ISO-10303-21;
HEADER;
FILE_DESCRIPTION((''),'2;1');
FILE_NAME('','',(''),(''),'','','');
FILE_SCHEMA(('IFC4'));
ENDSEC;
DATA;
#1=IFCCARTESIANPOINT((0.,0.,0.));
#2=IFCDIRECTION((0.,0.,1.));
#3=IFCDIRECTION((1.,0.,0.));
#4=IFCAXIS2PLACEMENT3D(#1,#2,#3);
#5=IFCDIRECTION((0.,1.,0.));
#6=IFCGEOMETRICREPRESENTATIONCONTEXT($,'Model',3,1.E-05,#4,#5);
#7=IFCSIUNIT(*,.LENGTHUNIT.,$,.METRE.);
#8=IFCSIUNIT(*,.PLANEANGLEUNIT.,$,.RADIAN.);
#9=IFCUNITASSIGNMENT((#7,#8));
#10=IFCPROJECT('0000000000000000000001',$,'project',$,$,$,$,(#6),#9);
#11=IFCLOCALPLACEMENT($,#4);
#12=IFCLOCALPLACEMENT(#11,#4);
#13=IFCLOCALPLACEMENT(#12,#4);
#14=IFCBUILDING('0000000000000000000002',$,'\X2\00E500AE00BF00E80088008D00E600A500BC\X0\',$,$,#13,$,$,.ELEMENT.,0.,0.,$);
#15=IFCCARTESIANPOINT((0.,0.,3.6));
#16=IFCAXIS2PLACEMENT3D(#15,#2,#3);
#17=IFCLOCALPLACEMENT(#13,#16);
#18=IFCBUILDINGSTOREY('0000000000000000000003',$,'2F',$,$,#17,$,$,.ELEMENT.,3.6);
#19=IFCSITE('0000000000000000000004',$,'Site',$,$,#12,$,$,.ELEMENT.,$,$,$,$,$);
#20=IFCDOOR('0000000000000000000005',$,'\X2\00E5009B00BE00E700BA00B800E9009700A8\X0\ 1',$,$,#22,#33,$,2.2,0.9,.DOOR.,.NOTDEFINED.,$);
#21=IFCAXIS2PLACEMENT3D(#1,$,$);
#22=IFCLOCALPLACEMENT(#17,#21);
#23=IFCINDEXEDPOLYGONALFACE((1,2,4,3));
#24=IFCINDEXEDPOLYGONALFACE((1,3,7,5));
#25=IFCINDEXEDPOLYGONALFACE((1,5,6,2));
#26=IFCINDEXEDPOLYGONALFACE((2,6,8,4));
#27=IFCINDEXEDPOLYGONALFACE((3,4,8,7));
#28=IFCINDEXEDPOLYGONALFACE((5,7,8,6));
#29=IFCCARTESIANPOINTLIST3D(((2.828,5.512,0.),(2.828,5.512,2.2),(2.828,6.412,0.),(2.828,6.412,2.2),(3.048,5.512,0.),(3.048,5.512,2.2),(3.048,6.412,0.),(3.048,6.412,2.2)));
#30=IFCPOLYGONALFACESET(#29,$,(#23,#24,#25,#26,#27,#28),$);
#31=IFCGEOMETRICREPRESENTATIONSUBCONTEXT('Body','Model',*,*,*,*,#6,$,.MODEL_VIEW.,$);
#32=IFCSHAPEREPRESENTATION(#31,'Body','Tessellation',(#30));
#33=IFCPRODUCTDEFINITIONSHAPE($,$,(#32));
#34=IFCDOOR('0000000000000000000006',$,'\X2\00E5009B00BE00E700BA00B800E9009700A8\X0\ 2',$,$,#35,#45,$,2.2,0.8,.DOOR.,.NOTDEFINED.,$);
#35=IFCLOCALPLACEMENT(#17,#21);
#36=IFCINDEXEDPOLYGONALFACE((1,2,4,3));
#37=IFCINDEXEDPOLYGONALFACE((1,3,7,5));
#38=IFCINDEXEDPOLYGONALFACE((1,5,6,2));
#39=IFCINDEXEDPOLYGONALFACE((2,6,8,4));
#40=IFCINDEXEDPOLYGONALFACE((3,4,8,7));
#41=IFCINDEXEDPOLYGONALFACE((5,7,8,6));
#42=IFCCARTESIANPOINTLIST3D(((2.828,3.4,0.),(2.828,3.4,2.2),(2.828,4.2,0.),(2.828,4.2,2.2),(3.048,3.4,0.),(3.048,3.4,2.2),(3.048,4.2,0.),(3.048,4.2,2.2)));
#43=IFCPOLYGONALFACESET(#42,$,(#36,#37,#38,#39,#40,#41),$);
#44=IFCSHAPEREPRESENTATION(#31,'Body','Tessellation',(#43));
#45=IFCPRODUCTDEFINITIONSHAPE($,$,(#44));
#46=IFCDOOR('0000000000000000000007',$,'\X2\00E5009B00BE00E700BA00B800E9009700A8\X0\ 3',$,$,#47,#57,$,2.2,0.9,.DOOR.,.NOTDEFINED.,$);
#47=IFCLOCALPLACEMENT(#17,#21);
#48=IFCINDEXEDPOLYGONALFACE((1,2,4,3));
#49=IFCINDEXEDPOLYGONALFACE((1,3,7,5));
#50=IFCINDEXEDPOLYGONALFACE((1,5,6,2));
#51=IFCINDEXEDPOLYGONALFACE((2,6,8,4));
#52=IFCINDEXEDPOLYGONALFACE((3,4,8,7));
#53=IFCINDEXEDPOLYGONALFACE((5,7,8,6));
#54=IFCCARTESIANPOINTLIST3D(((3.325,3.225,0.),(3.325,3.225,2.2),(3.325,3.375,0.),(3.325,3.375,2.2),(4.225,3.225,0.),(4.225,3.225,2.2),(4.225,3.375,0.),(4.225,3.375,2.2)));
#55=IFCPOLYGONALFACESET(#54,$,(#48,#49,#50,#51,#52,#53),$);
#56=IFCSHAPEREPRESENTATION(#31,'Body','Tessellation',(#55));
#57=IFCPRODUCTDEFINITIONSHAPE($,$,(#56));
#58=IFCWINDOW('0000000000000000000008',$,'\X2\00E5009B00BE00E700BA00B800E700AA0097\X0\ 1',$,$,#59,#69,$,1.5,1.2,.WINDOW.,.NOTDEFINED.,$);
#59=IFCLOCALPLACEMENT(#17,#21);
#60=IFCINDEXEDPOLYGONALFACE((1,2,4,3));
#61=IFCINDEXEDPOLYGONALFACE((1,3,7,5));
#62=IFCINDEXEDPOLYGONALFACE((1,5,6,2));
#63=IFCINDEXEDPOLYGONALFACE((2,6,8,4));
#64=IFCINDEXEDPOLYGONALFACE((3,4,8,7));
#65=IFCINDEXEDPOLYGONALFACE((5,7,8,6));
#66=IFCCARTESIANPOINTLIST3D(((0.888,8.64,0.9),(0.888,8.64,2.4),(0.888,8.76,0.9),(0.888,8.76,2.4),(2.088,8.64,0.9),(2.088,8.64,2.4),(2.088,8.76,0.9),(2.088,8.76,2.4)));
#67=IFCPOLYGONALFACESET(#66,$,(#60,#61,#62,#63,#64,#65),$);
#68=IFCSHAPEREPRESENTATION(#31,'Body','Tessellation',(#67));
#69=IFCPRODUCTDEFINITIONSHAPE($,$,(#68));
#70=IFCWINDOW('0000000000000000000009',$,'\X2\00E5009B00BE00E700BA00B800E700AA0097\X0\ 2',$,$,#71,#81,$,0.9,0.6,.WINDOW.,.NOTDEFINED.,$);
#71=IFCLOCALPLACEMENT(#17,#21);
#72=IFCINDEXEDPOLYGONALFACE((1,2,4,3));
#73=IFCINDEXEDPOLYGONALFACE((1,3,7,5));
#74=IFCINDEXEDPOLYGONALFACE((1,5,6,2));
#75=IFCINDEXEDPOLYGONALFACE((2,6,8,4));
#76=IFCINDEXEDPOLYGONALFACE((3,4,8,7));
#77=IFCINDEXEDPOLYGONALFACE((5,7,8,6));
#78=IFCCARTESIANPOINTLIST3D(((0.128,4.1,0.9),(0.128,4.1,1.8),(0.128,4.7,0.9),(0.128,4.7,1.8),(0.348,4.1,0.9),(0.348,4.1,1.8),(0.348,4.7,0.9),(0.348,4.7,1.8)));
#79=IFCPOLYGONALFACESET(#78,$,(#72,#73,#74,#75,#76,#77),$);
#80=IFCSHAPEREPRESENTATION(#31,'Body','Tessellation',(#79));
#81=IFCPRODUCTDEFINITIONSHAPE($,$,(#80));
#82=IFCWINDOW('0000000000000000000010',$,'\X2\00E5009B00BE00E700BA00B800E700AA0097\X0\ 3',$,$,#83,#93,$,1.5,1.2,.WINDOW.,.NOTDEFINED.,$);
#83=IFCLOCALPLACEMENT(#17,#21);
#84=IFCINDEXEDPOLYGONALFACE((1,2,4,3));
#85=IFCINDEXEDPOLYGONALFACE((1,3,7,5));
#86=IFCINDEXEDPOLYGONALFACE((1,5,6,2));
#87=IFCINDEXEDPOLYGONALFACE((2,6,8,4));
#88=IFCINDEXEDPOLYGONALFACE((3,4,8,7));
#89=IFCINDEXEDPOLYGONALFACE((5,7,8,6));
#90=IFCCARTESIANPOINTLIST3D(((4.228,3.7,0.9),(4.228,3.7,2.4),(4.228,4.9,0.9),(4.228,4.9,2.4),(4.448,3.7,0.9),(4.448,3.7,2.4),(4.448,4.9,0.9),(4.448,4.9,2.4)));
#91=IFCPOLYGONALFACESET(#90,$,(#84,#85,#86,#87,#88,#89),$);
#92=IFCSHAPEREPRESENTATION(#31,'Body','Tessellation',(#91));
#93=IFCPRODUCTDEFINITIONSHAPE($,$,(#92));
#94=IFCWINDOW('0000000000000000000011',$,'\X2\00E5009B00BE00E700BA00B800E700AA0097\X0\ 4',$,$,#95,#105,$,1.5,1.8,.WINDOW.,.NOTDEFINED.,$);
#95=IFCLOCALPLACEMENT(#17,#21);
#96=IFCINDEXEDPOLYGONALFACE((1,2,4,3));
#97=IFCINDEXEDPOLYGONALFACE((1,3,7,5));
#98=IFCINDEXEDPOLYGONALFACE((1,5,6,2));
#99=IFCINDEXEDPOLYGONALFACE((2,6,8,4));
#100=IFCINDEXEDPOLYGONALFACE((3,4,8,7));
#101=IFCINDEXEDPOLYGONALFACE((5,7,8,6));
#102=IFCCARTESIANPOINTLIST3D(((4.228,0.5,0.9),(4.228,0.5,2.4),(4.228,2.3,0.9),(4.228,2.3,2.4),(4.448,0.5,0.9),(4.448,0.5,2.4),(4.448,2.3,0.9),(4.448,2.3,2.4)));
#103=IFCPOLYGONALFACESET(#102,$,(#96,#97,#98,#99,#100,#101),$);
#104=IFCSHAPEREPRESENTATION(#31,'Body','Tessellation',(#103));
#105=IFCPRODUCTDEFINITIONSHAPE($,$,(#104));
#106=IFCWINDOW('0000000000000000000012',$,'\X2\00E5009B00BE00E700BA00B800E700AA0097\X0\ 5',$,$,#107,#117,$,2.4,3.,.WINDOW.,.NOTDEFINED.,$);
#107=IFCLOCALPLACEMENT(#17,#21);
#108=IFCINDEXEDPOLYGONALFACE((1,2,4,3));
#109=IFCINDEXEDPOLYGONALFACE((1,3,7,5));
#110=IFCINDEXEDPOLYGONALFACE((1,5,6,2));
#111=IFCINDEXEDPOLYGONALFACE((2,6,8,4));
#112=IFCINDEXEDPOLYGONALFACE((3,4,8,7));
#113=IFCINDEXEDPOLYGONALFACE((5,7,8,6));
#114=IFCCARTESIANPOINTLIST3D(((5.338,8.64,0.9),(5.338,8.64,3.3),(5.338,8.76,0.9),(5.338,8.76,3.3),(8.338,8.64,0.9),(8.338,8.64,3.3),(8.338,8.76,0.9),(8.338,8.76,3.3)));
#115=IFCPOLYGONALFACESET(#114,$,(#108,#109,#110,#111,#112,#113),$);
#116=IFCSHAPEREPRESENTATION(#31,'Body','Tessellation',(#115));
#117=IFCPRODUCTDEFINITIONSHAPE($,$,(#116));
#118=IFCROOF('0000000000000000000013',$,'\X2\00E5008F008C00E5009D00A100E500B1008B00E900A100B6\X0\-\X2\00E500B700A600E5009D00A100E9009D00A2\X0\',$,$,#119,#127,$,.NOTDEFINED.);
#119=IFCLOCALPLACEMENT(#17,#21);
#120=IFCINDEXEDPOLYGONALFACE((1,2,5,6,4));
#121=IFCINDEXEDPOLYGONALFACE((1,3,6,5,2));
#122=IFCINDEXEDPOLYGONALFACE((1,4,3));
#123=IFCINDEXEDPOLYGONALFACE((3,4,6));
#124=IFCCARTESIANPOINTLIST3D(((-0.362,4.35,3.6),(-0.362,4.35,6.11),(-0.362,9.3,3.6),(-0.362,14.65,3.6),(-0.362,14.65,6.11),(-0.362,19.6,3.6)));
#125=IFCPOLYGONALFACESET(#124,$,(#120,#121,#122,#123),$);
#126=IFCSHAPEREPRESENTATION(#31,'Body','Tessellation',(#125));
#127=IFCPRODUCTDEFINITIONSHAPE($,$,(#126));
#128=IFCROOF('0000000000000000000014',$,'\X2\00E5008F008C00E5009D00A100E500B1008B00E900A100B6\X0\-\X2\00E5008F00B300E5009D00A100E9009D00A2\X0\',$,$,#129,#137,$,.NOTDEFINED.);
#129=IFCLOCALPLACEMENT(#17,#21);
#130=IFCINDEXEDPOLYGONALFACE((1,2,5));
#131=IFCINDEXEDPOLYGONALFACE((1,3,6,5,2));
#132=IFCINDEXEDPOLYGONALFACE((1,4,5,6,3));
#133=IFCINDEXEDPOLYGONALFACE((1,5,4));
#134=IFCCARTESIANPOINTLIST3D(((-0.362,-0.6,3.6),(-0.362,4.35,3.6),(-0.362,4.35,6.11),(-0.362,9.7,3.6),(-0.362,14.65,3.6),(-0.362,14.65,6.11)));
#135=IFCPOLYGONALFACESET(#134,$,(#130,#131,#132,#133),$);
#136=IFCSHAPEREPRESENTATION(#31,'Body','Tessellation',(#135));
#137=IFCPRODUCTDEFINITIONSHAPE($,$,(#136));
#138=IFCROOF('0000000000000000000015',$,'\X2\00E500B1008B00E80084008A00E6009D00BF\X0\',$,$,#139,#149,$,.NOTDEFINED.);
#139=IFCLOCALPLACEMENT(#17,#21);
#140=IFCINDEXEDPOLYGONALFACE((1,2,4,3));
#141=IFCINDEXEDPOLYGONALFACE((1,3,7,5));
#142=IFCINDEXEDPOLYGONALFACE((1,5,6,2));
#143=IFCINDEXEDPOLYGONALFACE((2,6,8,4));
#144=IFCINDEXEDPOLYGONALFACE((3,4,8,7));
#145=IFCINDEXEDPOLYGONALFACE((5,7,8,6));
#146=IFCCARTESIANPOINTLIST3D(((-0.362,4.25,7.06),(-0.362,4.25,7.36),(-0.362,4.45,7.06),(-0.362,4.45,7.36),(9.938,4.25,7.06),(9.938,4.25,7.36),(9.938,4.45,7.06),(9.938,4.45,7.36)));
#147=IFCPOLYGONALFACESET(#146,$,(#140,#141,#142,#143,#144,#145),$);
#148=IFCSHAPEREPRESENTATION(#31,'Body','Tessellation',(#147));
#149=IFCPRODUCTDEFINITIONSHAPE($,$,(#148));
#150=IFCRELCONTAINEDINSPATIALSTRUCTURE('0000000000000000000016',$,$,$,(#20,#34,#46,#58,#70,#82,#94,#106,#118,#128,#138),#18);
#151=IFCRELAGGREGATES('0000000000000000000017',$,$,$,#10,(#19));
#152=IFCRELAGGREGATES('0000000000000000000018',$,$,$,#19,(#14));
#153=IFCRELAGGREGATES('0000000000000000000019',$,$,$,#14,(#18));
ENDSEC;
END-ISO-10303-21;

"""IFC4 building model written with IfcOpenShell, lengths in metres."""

from ifc_helpers import new_model, si_unit, direction, frame, frame_2d, origin_with_axes, place, context, subcontext, project, spatial, polyline, rectangle, outline, extrude, element, save


model = new_model("IFC4")

# Units and contexts
model_context = context("Model", 3, precision=1e-05, world=origin_with_axes(), true_north=direction((0.0, 1.0, 0.0)))
body_context = subcontext(model_context, "Body", "Model", "MODEL_VIEW")
ifc_project = project(units=[si_unit("LENGTHUNIT", "METRE"), si_unit("PLANEANGLEUNIT", "RADIAN")], contexts=[model_context])

# Site, building, storey
placement = place(None, origin_with_axes())
site_placement = place(placement, origin_with_axes())
site = spatial("IfcSite", under=ifc_project, at=site_placement, Name="Site", CompositionType="ELEMENT")
building_placement = place(site_placement, origin_with_axes())
building = spatial("IfcBuilding", under=site, at=building_placement, Name="å®¿è\u0088\u008dæ¥¼", CompositionType="ELEMENT", ElevationOfRefHeight=0.0, ElevationOfTerrain=0.0)
storey_placement = place(building_placement, frame((0.0, 0.0, 3.6), z_axis=(0.0, 0.0, 1.0), x_axis=(1.0, 0.0, 0.0)))
storey = spatial("IfcBuildingStorey", under=building, at=storey_placement, Name="2F", CompositionType="ELEMENT", Elevation=3.6)

# Doors
door_1_placement = place(storey_placement, frame((2.938, 5.962, 0.0), z_axis=(0.0, 0.0, 1.0), x_axis=(0.0, 1.0, 0.0)))
element("IfcDoor", 1, at=door_1_placement, inside=storey, Name="å\u009b¾çº¸é\u0097¨ 1", OperationType="NOTDEFINED", OverallHeight=2.2, OverallWidth=0.9, PredefinedType="DOOR", context=body_context, shape_type="SweptSolid", body=[
    extrude(rectangle(XDim=0.9, YDim=0.22, at=frame_2d((0.0, 0.0), x_axis=(1.0, 0.0, 0.0))), frame((0.0, 0.0, 0.0), z_axis=(0.0, 0.0, 1.0)), (0.0, 0.0, 1.0), 2.2),
])
door_2_placement = place(storey_placement, frame((2.938, 3.8, 0.0), z_axis=(0.0, 0.0, 1.0), x_axis=(0.0, 1.0, 0.0)))
element("IfcDoor", 2, at=door_2_placement, inside=storey, Name="å\u009b¾çº¸é\u0097¨ 2", OperationType="NOTDEFINED", OverallHeight=2.2, OverallWidth=0.8, PredefinedType="DOOR", context=body_context, shape_type="SweptSolid", body=[
    extrude(rectangle(XDim=0.8, YDim=0.22, at=frame_2d((0.0, 0.0), x_axis=(1.0, 0.0, 0.0))), frame((0.0, 0.0, 0.0), z_axis=(0.0, 0.0, 1.0)), (0.0, 0.0, 1.0), 2.2),
])
door_3_placement = place(storey_placement, frame((3.775, 3.3, 0.0), z_axis=(0.0, 0.0, 1.0), x_axis=(1.0, 0.0, 0.0)))
element("IfcDoor", 3, at=door_3_placement, inside=storey, Name="å\u009b¾çº¸é\u0097¨ 3", OperationType="NOTDEFINED", OverallHeight=2.2, OverallWidth=0.9, PredefinedType="DOOR", context=body_context, shape_type="SweptSolid", body=[
    extrude(rectangle(XDim=0.9, YDim=0.15, at=frame_2d((0.0, 0.0), x_axis=(1.0, 0.0, 0.0))), frame((0.0, 0.0, 0.0), z_axis=(0.0, 0.0, 1.0)), (0.0, 0.0, 1.0), 2.2),
])

# Windows
window_1_placement = place(storey_placement, frame((1.488, 8.7, 0.9), z_axis=(0.0, 0.0, 1.0), x_axis=(1.0, 0.0, 0.0)))
element("IfcWindow", 4, at=window_1_placement, inside=storey, Name="å\u009b¾çº¸çª\u0097 1", OverallHeight=1.5, OverallWidth=1.2, PartitioningType="NOTDEFINED", PredefinedType="WINDOW", context=body_context, shape_type="SweptSolid", body=[
    extrude(rectangle(XDim=1.2, YDim=0.12, at=frame_2d((0.0, 0.0), x_axis=(1.0, 0.0, 0.0))), frame((0.0, 0.0, 0.0), z_axis=(0.0, 0.0, 1.0)), (0.0, 0.0, 1.0), 1.5),
])
window_2_placement = place(storey_placement, frame((0.238, 4.4, 0.9), z_axis=(0.0, 0.0, 1.0), x_axis=(0.0, 1.0, 0.0)))
element("IfcWindow", 5, at=window_2_placement, inside=storey, Name="å\u009b¾çº¸çª\u0097 2", OverallHeight=0.9, OverallWidth=0.6, PartitioningType="NOTDEFINED", PredefinedType="WINDOW", context=body_context, shape_type="SweptSolid", body=[
    extrude(rectangle(XDim=0.6, YDim=0.22, at=frame_2d((0.0, 0.0), x_axis=(1.0, 0.0, 0.0))), frame((0.0, 0.0, 0.0), z_axis=(0.0, 0.0, 1.0)), (0.0, 0.0, 1.0), 0.9),
])
window_3_placement = place(storey_placement, frame((4.338, 4.3, 0.9), z_axis=(0.0, 0.0, 1.0), x_axis=(0.0, 1.0, 0.0)))
element("IfcWindow", 6, at=window_3_placement, inside=storey, Name="å\u009b¾çº¸çª\u0097 3", OverallHeight=1.5, OverallWidth=1.2, PartitioningType="NOTDEFINED", PredefinedType="WINDOW", context=body_context, shape_type="SweptSolid", body=[
    extrude(rectangle(XDim=1.2, YDim=0.22, at=frame_2d((0.0, 0.0), x_axis=(1.0, 0.0, 0.0))), frame((0.0, 0.0, 0.0), z_axis=(0.0, 0.0, 1.0)), (0.0, 0.0, 1.0), 1.5),
])
window_4_placement = place(storey_placement, frame((4.338, 1.4, 0.9), z_axis=(0.0, 0.0, 1.0), x_axis=(0.0, 1.0, 0.0)))
element("IfcWindow", 7, at=window_4_placement, inside=storey, Name="å\u009b¾çº¸çª\u0097 4", OverallHeight=1.5, OverallWidth=1.8, PartitioningType="NOTDEFINED", PredefinedType="WINDOW", context=body_context, shape_type="SweptSolid", body=[
    extrude(rectangle(XDim=1.8, YDim=0.22, at=frame_2d((0.0, 0.0), x_axis=(1.0, 0.0, 0.0))), frame((0.0, 0.0, 0.0), z_axis=(0.0, 0.0, 1.0)), (0.0, 0.0, 1.0), 1.5),
])
window_5_placement = place(storey_placement, frame((6.838, 8.7, 0.9), z_axis=(0.0, 0.0, 1.0), x_axis=(-1.0, 0.0, 0.0)))
element("IfcWindow", 8, at=window_5_placement, inside=storey, Name="å\u009b¾çº¸çª\u0097 5", OverallHeight=2.4, OverallWidth=3.0, PartitioningType="NOTDEFINED", PredefinedType="WINDOW", context=body_context, shape_type="SweptSolid", body=[
    extrude(rectangle(XDim=3.0, YDim=0.12, at=frame_2d((0.0, 0.0), x_axis=(1.0, 0.0, 0.0))), frame((0.0, 0.0, 0.0), z_axis=(0.0, 0.0, 1.0)), (0.0, 0.0, 1.0), 2.4),
])

# Roofs
roof_1_placement = place(storey_placement, frame((4.788, 4.35, 3.6), z_axis=(0.0, 0.0, 1.0), x_axis=(1.0, 0.0, 0.0)))
element("IfcRoof", 9, at=roof_1_placement, inside=storey, Name="å\u008f\u008cå\u009d¡å±\u008bé¡¶-å·¦å\u009d¡é\u009d¢", PredefinedType="NOTDEFINED", context=body_context, shape_type="SweptSolid", body=[
    extrude(outline(polyline([(0.0, 0.0), (4.95, 0.0), (0.0, 2.51), (0.0, 0.0)])), frame((-5.15, 0.0, 0.0), z_axis=(1.0, 0.0, 0.0), x_axis=(0.0, 1.0, 0.0)), (1.0, 0.0, 0.0), 10.3),
])
roof_2_placement = place(storey_placement, frame((4.788, 4.35, 3.6), z_axis=(0.0, 0.0, 1.0), x_axis=(1.0, 0.0, 0.0)))
element("IfcRoof", 10, at=roof_2_placement, inside=storey, Name="å\u008f\u008cå\u009d¡å±\u008bé¡¶-å\u008f³å\u009d¡é\u009d¢", PredefinedType="NOTDEFINED", context=body_context, shape_type="SweptSolid", body=[
    extrude(outline(polyline([(0.0, 0.0), (-4.95, 0.0), (0.0, 2.51), (0.0, 0.0)])), frame((-5.15, 0.0, 0.0), z_axis=(1.0, 0.0, 0.0), x_axis=(0.0, 1.0, 0.0)), (1.0, 0.0, 0.0), 10.3),
])
roof_3_placement = place(storey_placement, frame((4.788, 4.35, 7.06), z_axis=(0.0, 0.0, 1.0), x_axis=(1.0, 0.0, 0.0)))
element("IfcRoof", 11, at=roof_3_placement, inside=storey, Name="å±\u008bè\u0084\u008aæ\u009d¿", PredefinedType="NOTDEFINED", context=body_context, shape_type="SweptSolid", body=[
    extrude(rectangle(XDim=10.3, YDim=0.2, at=frame_2d((0.0, 0.0), x_axis=(1.0, 0.0, 0.0))), frame((0.0, 0.0, 0.0), z_axis=(0.0, 0.0, 1.0)), (0.0, 0.0, 1.0), 0.3),
])

save(model, "model.ifc")
